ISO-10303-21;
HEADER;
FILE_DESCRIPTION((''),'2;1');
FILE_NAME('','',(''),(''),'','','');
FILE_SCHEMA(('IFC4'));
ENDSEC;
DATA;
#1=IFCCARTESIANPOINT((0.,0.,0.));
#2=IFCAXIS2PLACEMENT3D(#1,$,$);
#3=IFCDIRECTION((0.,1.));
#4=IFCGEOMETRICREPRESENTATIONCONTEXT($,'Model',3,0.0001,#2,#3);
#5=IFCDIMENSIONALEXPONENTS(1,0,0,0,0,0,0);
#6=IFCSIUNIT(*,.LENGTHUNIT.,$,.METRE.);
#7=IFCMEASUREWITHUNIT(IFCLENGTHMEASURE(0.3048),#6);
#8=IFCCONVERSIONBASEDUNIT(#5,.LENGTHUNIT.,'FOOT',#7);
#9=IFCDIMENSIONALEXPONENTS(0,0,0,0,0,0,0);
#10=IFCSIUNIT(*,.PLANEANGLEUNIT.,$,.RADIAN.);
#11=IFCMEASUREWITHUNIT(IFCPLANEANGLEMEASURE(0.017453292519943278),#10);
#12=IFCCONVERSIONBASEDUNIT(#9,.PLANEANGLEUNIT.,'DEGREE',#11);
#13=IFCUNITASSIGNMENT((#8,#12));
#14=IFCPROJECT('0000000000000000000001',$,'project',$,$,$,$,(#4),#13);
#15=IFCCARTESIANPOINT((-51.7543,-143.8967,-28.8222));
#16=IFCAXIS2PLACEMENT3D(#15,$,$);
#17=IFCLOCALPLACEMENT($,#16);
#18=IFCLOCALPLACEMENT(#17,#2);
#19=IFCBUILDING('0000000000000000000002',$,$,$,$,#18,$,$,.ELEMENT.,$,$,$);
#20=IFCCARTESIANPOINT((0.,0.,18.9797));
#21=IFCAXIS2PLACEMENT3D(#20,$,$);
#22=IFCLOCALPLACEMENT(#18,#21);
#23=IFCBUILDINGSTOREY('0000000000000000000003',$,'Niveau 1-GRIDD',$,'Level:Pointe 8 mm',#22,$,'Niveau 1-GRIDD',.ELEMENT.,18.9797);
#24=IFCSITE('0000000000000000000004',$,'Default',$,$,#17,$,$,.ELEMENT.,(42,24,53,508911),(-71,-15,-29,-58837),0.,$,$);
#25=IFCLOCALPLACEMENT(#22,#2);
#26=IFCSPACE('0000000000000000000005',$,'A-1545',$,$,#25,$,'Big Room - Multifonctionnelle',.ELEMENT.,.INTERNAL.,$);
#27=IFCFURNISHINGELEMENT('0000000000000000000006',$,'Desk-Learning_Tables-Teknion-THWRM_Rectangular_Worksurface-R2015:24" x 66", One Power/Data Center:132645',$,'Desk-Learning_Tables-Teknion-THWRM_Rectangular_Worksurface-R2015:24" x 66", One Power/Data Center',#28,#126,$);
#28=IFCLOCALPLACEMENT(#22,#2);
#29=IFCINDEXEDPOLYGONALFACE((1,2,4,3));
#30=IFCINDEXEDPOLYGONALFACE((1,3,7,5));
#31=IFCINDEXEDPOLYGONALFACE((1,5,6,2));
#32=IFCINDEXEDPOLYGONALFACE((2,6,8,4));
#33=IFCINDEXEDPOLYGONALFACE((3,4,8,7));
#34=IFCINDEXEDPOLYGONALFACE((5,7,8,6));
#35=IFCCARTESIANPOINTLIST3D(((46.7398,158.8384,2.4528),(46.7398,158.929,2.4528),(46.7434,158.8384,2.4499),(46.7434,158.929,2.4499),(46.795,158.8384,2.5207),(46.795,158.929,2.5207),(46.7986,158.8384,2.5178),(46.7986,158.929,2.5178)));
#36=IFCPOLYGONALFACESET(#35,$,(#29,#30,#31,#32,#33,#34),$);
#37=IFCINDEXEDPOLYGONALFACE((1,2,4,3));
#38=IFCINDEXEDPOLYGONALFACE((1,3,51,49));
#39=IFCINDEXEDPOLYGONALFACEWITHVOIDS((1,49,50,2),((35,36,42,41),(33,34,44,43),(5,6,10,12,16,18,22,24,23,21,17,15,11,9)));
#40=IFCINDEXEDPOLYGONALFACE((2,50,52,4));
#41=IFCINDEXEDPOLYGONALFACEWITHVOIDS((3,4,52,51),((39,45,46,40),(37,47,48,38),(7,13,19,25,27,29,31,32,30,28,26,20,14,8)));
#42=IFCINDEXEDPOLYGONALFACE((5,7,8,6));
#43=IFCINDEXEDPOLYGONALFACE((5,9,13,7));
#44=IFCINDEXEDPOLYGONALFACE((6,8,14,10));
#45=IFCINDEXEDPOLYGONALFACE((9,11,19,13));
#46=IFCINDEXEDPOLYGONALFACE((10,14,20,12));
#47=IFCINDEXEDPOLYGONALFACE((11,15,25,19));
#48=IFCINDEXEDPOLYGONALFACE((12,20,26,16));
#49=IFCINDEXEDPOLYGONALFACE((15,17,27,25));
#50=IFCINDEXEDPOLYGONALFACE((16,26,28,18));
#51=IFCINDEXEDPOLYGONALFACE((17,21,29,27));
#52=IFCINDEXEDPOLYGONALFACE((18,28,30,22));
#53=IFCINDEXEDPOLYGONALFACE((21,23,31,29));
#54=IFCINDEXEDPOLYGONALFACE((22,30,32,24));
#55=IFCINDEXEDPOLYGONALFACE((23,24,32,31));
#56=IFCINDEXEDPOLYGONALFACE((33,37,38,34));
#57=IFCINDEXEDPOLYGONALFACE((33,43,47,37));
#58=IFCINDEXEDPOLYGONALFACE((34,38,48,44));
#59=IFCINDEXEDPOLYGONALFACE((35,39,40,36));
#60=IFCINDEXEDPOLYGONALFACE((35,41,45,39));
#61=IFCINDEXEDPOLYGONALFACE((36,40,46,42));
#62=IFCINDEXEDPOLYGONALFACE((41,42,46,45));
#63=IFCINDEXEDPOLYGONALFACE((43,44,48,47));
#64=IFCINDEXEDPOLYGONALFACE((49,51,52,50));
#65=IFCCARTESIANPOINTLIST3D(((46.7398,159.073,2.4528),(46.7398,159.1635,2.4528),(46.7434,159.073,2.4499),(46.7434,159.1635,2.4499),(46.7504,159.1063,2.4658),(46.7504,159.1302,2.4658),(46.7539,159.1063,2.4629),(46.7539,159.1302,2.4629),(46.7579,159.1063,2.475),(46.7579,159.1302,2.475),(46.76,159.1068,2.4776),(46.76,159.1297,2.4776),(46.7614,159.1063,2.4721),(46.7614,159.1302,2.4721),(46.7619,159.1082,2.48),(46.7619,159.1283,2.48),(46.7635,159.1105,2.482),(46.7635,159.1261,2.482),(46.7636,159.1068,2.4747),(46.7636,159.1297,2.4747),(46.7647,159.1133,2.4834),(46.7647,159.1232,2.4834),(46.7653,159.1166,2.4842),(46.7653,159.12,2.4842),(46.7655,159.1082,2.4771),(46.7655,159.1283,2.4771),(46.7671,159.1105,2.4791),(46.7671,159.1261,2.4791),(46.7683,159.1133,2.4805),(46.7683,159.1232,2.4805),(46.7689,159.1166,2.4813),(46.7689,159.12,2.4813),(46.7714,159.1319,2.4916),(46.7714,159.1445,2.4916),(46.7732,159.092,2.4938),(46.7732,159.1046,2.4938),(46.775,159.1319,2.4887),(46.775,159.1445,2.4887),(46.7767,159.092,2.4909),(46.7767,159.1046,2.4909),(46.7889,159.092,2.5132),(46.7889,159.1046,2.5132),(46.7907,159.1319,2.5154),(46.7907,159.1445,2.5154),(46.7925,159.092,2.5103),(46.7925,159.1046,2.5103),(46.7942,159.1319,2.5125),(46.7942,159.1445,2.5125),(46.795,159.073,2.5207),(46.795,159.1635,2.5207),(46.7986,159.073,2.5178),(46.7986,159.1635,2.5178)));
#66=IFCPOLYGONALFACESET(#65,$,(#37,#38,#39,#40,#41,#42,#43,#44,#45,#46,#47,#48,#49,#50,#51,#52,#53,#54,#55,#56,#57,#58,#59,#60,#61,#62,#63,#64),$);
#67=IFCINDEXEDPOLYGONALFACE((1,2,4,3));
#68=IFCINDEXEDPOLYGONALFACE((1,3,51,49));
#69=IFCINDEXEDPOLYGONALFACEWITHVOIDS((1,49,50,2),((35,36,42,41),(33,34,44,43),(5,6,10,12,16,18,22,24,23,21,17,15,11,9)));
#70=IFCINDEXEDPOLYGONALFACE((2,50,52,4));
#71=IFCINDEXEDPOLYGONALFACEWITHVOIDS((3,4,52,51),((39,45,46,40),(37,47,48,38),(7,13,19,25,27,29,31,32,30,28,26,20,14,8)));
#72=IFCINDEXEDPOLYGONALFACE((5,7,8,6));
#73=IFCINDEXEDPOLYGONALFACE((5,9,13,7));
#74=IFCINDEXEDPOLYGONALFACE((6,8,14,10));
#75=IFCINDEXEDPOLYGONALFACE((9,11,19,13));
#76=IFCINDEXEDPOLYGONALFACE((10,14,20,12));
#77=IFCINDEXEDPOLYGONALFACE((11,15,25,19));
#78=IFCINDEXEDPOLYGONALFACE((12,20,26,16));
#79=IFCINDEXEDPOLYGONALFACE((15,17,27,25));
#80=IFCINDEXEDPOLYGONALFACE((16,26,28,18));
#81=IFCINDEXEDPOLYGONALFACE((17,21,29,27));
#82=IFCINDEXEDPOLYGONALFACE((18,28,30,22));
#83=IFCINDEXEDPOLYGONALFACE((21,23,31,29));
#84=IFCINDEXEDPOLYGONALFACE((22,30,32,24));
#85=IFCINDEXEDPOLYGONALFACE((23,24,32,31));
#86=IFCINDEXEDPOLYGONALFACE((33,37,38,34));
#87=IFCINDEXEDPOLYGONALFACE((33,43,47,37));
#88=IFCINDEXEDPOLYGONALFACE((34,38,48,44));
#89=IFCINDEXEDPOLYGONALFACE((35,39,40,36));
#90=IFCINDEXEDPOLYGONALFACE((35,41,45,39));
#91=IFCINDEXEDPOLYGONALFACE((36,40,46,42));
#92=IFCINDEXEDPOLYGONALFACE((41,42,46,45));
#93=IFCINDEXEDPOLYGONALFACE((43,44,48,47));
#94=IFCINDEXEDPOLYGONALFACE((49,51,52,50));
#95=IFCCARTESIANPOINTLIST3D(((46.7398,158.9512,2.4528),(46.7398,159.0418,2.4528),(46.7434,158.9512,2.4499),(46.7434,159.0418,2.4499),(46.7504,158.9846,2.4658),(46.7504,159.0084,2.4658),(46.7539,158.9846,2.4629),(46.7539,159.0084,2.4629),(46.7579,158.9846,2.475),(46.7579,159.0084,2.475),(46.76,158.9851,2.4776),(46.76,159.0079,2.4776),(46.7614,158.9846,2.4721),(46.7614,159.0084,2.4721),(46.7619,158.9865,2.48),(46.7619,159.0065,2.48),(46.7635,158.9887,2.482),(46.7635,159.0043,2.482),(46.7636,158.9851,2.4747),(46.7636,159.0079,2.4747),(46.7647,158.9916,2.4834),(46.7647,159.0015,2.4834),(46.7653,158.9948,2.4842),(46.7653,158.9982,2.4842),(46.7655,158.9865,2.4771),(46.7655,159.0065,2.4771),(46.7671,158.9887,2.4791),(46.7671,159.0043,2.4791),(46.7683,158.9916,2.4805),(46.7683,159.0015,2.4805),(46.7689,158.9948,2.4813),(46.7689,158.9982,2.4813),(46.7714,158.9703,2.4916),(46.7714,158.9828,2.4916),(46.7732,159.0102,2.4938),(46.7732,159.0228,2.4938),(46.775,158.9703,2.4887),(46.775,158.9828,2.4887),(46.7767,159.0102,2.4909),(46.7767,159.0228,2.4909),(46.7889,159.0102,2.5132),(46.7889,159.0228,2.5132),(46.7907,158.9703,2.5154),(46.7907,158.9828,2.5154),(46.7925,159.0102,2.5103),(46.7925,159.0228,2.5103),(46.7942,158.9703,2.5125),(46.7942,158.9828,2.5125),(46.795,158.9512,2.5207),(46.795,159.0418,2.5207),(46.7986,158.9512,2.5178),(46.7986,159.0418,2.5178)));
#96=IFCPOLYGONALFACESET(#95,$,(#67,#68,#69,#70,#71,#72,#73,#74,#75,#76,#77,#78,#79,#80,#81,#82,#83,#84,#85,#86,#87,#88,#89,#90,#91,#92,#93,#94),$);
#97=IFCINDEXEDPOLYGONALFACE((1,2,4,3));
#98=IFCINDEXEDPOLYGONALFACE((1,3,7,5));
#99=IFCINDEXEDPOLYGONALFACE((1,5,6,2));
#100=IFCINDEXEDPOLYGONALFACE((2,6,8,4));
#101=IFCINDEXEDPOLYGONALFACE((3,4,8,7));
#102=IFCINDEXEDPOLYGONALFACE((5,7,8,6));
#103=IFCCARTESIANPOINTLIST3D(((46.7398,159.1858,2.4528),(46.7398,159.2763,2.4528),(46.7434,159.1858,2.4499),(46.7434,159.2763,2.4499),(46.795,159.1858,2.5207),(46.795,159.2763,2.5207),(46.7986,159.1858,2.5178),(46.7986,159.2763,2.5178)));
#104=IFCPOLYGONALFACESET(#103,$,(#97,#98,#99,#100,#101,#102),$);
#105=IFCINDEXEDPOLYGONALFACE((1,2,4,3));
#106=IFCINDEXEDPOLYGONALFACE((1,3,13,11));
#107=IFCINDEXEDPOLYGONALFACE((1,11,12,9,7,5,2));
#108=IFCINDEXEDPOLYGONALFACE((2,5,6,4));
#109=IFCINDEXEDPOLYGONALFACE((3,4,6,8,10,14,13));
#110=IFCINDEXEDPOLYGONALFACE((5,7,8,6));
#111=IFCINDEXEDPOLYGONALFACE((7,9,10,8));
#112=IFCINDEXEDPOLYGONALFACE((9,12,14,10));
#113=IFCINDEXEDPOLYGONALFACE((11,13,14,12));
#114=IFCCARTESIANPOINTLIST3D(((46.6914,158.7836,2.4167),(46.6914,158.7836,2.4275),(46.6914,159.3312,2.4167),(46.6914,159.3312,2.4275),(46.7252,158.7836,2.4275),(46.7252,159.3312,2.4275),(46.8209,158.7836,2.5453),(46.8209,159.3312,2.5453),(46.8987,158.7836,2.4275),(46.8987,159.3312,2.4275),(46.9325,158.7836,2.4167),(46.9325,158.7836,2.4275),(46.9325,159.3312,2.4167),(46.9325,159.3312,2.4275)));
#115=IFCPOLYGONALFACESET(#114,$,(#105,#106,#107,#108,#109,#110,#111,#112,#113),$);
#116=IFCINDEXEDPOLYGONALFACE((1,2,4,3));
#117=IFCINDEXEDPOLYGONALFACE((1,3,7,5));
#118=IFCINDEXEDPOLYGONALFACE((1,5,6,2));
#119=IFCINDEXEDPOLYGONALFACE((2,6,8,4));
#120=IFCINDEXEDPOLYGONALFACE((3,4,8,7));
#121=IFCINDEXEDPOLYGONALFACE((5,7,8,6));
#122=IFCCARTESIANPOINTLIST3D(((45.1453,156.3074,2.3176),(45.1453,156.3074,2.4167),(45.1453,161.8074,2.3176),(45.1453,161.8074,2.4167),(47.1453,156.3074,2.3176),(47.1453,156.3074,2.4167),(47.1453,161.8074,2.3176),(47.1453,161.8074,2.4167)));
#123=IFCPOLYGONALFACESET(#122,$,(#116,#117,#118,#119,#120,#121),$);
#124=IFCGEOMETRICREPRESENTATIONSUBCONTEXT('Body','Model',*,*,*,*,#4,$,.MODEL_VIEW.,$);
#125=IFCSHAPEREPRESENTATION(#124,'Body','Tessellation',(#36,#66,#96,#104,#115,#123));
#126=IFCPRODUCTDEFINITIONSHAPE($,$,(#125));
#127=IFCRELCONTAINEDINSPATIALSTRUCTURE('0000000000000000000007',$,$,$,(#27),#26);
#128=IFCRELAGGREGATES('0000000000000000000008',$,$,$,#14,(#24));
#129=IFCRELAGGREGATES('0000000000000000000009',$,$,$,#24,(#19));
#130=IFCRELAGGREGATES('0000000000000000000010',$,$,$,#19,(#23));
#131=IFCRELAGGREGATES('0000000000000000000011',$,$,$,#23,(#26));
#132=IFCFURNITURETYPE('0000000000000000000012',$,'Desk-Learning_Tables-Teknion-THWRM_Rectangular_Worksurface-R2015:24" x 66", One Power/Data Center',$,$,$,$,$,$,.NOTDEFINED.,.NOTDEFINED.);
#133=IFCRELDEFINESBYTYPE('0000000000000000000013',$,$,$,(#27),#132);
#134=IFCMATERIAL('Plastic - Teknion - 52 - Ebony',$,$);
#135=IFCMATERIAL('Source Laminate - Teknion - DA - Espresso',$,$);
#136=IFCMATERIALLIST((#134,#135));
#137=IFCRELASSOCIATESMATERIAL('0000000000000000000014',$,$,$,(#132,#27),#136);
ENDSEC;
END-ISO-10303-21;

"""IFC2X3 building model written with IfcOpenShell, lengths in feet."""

from ifc_helpers import new_model, entity, si_unit, converted_unit, direction, frame, frame_2d, origin, place, context, subcontext, project, spatial, polyline, circle_curve, parameter, trimmed, segment, composite_curve, rectangle, outline, extrude, source, transform, mapped, material, material_list, type_object, type_shapes, element, save


model = new_model("IFC2X3")

# Units and contexts
model_context = context("Model", 3, precision=0.0001, world=origin(), true_north=direction((0.0, 1.0)))
body_context = subcontext(model_context, "Body", "Model", "MODEL_VIEW")
ifc_project = project(units=[converted_unit("LENGTHUNIT", "FOOT", entity("IfcLengthMeasure", 0.3048), si_unit("LENGTHUNIT", "METRE"), dimensions=[1, 0, 0, 0, 0, 0, 0]), converted_unit("PLANEANGLEUNIT", "DEGREE", entity("IfcPlaneAngleMeasure", 0.017453292519943278), si_unit("PLANEANGLEUNIT", "RADIAN"), dimensions=[0, 0, 0, 0, 0, 0, 0])], contexts=[model_context])

# Site, building, storey
site_placement = place(None, frame((-51.7543, -143.8967, -28.8222)))
site = spatial("IfcSite", under=ifc_project, at=site_placement, Name="Default", CompositionType="ELEMENT", RefLatitude=(42, 24, 53, 508911), RefLongitude=(-71, -15, -29, -58837), RefElevation=0.0)
building_placement = place(site_placement, origin())
building = spatial("IfcBuilding", under=site, at=building_placement, CompositionType="ELEMENT")
storey_placement = place(building_placement, frame((0.0, 0.0, 18.9797)))
storey = spatial("IfcBuildingStorey", under=building, at=storey_placement, Name="Niveau 1-GRIDD", ObjectType="Level:Pointe 8 mm", LongName="Niveau 1-GRIDD", CompositionType="ELEMENT", Elevation=18.9797)

# Shared definitions
space_1_placement = place(storey_placement, origin())
space_1 = spatial("IfcSpace", under=storey, at=space_1_placement, Name="A-1545", LongName="Big Room - Multifonctionnelle", CompositionType="ELEMENT", InteriorOrExteriorSpace="INTERNAL")

# Furnishing element
ifc_material_1 = material(Name="Plastic - Teknion - 52 - Ebony")
ifc_material_2 = material(Name="Source Laminate - Teknion - DA - Espresso")
ifc_material_list_1 = material_list([ifc_material_1, ifc_material_2])
furniture_type_1 = type_object("IfcFurnitureType", Name="Desk-Learning_Tables-Teknion-THWRM_Rectangular_Worksurface-R2015:24\" x 66\", One Power/Data Center", AssemblyPlace="NOTDEFINED", material=ifc_material_list_1)
shared_shape_1 = source(origin(), body_context, "Body", "SweptSolid", [
    extrude(rectangle(XDim=0.0875, YDim=0.0046, at=frame_2d((0.0, 0.0), x_axis=(0.0, 1.0))), frame((0.1284, 0.6239, 2.4853), z_axis=(1.0, 0.0, 0.0), x_axis=(0.0, 0.776046, -0.630676)), (0.0, 0.0, 1.0), 0.0906),
    extrude(outline(polyline([(-0.0453, -0.0438), (0.0453, -0.0438), (0.0453, 0.0438), (-0.0453, 0.0438), (-0.0453, -0.0438)]), holes=[polyline([(-0.0262, -0.0063), (-0.0137, -0.0063), (-0.0137, -0.0369), (-0.0262, -0.0369), (-0.0262, -0.0063)]), polyline([(0.0137, -0.0341), (0.0137, -0.0091), (0.0262, -0.0091), (0.0262, -0.0341), (0.0137, -0.0341)]), composite_curve([segment(polyline([(-0.0119, 0.027), (0.0119, 0.027)]), True, "CONTINUOUS"), segment(polyline([(0.0119, 0.027), (0.0119, 0.0151)]), True, "CONTINUOUS"), segment(trimmed(circle_curve(frame_2d((0.0, 0.0151), x_axis=(0.0, -1.0)), 0.0119), [parameter(270.0)], [parameter(90.0)], True, "PARAMETER"), False, "CONTINUOUS"), segment(polyline([(-0.0119, 0.0151), (-0.0119, 0.027)]), True, "CONTINUOUS")], self_intersect=False)]), frame((-0.0609, 0.6221, 2.4867), z_axis=(0.0, 0.776046, -0.630676), x_axis=(1.0, 0.0, 0.0)), (0.0, 0.0, 1.0), 0.0046),
    extrude(outline(polyline([(-0.0438, -0.0453), (0.0438, -0.0453), (0.0438, 0.0453), (-0.0438, 0.0453), (-0.0438, -0.0453)]), holes=[polyline([(-0.0063, -0.0262), (-0.0369, -0.0262), (-0.0369, -0.0137), (-0.0063, -0.0137), (-0.0063, -0.0262)]), polyline([(-0.0341, 0.0137), (-0.0341, 0.0262), (-0.0091, 0.0262), (-0.0091, 0.0137), (-0.0341, 0.0137)]), composite_curve([segment(polyline([(0.027, -0.0119), (0.0151, -0.0119)]), True, "CONTINUOUS"), segment(trimmed(circle_curve(frame_2d((0.0151, 0.0), x_axis=(-1.0, 0.0)), 0.0119), [parameter(270.0)], [parameter(90.0)], True, "PARAMETER"), False, "CONTINUOUS"), segment(polyline([(0.0151, 0.0119), (0.027, 0.0119)]), True, "CONTINUOUS"), segment(polyline([(0.027, 0.0119), (0.027, -0.0119)]), True, "CONTINUOUS")], self_intersect=False)]), frame((0.0609, 0.6221, 2.4867), z_axis=(0.0, 0.776046, -0.630676), x_axis=(0.0, -0.630676, -0.776046)), (0.0, 0.0, 1.0), 0.0046),
    extrude(rectangle(XDim=0.0875, YDim=0.0046, at=frame_2d((0.0, 0.0), x_axis=(0.0, 1.0))), frame((-0.219, 0.6239, 2.4853), z_axis=(1.0, 0.0, 0.0), x_axis=(0.0, 0.776046, -0.630676)), (0.0, 0.0, 1.0), 0.0906),
    extrude(outline(polyline([(-0.0586, -0.0638), (0.0826, -0.0638), (0.0371, 0.0811), (0.0557, 0.1093), (0.0467, 0.1152), (-0.0862, -0.086), (-0.0772, -0.092), (-0.0586, -0.0638)])), frame((-0.2738, 0.6679, 2.4412), z_axis=(1.0, 0.0, 0.0), x_axis=(0.0, -0.551103, 0.834437)), (0.0, 0.0, 1.0), 0.5475),
    extrude(rectangle(XDim=5.5, YDim=2.0, at=frame_2d((0.0, 0.0), x_axis=(1.0, 0.0))), frame((0.0, 0.0, 2.3176), z_axis=(0.0, 0.0, 1.0), x_axis=(-1.0, 0.0, 0.0)), (0.0, 0.0, 1.0), 0.0991),
])
type_shapes(furniture_type_1, [shared_shape_1])
for number, where, z_axis, x_axis, name in (
    (1, (46.1453, 159.0574, 0.0), (0.0, 0.0, 1.0), (0.0, -1.0, 0.0), "Desk-Learning_Tables-Teknion-THWRM_Rectangular_Worksurface-R2015:24\" x 66\", One Power/Data Center:132645"),
):
    element("IfcFurnishingElement", number, at=place(space_1_placement, frame(where, z_axis=z_axis, x_axis=x_axis)), inside=space_1, type_object=furniture_type_1, material=ifc_material_list_1, Name=name, ObjectType="Desk-Learning_Tables-Teknion-THWRM_Rectangular_Worksurface-R2015:24\" x 66\", One Power/Data Center", context=body_context, shape_type="MappedRepresentation", body=[
        mapped(shared_shape_1, transform((0.0, 0.0, 0.0), scale=1.0)),
    ])

save(model, "model.ifc")
